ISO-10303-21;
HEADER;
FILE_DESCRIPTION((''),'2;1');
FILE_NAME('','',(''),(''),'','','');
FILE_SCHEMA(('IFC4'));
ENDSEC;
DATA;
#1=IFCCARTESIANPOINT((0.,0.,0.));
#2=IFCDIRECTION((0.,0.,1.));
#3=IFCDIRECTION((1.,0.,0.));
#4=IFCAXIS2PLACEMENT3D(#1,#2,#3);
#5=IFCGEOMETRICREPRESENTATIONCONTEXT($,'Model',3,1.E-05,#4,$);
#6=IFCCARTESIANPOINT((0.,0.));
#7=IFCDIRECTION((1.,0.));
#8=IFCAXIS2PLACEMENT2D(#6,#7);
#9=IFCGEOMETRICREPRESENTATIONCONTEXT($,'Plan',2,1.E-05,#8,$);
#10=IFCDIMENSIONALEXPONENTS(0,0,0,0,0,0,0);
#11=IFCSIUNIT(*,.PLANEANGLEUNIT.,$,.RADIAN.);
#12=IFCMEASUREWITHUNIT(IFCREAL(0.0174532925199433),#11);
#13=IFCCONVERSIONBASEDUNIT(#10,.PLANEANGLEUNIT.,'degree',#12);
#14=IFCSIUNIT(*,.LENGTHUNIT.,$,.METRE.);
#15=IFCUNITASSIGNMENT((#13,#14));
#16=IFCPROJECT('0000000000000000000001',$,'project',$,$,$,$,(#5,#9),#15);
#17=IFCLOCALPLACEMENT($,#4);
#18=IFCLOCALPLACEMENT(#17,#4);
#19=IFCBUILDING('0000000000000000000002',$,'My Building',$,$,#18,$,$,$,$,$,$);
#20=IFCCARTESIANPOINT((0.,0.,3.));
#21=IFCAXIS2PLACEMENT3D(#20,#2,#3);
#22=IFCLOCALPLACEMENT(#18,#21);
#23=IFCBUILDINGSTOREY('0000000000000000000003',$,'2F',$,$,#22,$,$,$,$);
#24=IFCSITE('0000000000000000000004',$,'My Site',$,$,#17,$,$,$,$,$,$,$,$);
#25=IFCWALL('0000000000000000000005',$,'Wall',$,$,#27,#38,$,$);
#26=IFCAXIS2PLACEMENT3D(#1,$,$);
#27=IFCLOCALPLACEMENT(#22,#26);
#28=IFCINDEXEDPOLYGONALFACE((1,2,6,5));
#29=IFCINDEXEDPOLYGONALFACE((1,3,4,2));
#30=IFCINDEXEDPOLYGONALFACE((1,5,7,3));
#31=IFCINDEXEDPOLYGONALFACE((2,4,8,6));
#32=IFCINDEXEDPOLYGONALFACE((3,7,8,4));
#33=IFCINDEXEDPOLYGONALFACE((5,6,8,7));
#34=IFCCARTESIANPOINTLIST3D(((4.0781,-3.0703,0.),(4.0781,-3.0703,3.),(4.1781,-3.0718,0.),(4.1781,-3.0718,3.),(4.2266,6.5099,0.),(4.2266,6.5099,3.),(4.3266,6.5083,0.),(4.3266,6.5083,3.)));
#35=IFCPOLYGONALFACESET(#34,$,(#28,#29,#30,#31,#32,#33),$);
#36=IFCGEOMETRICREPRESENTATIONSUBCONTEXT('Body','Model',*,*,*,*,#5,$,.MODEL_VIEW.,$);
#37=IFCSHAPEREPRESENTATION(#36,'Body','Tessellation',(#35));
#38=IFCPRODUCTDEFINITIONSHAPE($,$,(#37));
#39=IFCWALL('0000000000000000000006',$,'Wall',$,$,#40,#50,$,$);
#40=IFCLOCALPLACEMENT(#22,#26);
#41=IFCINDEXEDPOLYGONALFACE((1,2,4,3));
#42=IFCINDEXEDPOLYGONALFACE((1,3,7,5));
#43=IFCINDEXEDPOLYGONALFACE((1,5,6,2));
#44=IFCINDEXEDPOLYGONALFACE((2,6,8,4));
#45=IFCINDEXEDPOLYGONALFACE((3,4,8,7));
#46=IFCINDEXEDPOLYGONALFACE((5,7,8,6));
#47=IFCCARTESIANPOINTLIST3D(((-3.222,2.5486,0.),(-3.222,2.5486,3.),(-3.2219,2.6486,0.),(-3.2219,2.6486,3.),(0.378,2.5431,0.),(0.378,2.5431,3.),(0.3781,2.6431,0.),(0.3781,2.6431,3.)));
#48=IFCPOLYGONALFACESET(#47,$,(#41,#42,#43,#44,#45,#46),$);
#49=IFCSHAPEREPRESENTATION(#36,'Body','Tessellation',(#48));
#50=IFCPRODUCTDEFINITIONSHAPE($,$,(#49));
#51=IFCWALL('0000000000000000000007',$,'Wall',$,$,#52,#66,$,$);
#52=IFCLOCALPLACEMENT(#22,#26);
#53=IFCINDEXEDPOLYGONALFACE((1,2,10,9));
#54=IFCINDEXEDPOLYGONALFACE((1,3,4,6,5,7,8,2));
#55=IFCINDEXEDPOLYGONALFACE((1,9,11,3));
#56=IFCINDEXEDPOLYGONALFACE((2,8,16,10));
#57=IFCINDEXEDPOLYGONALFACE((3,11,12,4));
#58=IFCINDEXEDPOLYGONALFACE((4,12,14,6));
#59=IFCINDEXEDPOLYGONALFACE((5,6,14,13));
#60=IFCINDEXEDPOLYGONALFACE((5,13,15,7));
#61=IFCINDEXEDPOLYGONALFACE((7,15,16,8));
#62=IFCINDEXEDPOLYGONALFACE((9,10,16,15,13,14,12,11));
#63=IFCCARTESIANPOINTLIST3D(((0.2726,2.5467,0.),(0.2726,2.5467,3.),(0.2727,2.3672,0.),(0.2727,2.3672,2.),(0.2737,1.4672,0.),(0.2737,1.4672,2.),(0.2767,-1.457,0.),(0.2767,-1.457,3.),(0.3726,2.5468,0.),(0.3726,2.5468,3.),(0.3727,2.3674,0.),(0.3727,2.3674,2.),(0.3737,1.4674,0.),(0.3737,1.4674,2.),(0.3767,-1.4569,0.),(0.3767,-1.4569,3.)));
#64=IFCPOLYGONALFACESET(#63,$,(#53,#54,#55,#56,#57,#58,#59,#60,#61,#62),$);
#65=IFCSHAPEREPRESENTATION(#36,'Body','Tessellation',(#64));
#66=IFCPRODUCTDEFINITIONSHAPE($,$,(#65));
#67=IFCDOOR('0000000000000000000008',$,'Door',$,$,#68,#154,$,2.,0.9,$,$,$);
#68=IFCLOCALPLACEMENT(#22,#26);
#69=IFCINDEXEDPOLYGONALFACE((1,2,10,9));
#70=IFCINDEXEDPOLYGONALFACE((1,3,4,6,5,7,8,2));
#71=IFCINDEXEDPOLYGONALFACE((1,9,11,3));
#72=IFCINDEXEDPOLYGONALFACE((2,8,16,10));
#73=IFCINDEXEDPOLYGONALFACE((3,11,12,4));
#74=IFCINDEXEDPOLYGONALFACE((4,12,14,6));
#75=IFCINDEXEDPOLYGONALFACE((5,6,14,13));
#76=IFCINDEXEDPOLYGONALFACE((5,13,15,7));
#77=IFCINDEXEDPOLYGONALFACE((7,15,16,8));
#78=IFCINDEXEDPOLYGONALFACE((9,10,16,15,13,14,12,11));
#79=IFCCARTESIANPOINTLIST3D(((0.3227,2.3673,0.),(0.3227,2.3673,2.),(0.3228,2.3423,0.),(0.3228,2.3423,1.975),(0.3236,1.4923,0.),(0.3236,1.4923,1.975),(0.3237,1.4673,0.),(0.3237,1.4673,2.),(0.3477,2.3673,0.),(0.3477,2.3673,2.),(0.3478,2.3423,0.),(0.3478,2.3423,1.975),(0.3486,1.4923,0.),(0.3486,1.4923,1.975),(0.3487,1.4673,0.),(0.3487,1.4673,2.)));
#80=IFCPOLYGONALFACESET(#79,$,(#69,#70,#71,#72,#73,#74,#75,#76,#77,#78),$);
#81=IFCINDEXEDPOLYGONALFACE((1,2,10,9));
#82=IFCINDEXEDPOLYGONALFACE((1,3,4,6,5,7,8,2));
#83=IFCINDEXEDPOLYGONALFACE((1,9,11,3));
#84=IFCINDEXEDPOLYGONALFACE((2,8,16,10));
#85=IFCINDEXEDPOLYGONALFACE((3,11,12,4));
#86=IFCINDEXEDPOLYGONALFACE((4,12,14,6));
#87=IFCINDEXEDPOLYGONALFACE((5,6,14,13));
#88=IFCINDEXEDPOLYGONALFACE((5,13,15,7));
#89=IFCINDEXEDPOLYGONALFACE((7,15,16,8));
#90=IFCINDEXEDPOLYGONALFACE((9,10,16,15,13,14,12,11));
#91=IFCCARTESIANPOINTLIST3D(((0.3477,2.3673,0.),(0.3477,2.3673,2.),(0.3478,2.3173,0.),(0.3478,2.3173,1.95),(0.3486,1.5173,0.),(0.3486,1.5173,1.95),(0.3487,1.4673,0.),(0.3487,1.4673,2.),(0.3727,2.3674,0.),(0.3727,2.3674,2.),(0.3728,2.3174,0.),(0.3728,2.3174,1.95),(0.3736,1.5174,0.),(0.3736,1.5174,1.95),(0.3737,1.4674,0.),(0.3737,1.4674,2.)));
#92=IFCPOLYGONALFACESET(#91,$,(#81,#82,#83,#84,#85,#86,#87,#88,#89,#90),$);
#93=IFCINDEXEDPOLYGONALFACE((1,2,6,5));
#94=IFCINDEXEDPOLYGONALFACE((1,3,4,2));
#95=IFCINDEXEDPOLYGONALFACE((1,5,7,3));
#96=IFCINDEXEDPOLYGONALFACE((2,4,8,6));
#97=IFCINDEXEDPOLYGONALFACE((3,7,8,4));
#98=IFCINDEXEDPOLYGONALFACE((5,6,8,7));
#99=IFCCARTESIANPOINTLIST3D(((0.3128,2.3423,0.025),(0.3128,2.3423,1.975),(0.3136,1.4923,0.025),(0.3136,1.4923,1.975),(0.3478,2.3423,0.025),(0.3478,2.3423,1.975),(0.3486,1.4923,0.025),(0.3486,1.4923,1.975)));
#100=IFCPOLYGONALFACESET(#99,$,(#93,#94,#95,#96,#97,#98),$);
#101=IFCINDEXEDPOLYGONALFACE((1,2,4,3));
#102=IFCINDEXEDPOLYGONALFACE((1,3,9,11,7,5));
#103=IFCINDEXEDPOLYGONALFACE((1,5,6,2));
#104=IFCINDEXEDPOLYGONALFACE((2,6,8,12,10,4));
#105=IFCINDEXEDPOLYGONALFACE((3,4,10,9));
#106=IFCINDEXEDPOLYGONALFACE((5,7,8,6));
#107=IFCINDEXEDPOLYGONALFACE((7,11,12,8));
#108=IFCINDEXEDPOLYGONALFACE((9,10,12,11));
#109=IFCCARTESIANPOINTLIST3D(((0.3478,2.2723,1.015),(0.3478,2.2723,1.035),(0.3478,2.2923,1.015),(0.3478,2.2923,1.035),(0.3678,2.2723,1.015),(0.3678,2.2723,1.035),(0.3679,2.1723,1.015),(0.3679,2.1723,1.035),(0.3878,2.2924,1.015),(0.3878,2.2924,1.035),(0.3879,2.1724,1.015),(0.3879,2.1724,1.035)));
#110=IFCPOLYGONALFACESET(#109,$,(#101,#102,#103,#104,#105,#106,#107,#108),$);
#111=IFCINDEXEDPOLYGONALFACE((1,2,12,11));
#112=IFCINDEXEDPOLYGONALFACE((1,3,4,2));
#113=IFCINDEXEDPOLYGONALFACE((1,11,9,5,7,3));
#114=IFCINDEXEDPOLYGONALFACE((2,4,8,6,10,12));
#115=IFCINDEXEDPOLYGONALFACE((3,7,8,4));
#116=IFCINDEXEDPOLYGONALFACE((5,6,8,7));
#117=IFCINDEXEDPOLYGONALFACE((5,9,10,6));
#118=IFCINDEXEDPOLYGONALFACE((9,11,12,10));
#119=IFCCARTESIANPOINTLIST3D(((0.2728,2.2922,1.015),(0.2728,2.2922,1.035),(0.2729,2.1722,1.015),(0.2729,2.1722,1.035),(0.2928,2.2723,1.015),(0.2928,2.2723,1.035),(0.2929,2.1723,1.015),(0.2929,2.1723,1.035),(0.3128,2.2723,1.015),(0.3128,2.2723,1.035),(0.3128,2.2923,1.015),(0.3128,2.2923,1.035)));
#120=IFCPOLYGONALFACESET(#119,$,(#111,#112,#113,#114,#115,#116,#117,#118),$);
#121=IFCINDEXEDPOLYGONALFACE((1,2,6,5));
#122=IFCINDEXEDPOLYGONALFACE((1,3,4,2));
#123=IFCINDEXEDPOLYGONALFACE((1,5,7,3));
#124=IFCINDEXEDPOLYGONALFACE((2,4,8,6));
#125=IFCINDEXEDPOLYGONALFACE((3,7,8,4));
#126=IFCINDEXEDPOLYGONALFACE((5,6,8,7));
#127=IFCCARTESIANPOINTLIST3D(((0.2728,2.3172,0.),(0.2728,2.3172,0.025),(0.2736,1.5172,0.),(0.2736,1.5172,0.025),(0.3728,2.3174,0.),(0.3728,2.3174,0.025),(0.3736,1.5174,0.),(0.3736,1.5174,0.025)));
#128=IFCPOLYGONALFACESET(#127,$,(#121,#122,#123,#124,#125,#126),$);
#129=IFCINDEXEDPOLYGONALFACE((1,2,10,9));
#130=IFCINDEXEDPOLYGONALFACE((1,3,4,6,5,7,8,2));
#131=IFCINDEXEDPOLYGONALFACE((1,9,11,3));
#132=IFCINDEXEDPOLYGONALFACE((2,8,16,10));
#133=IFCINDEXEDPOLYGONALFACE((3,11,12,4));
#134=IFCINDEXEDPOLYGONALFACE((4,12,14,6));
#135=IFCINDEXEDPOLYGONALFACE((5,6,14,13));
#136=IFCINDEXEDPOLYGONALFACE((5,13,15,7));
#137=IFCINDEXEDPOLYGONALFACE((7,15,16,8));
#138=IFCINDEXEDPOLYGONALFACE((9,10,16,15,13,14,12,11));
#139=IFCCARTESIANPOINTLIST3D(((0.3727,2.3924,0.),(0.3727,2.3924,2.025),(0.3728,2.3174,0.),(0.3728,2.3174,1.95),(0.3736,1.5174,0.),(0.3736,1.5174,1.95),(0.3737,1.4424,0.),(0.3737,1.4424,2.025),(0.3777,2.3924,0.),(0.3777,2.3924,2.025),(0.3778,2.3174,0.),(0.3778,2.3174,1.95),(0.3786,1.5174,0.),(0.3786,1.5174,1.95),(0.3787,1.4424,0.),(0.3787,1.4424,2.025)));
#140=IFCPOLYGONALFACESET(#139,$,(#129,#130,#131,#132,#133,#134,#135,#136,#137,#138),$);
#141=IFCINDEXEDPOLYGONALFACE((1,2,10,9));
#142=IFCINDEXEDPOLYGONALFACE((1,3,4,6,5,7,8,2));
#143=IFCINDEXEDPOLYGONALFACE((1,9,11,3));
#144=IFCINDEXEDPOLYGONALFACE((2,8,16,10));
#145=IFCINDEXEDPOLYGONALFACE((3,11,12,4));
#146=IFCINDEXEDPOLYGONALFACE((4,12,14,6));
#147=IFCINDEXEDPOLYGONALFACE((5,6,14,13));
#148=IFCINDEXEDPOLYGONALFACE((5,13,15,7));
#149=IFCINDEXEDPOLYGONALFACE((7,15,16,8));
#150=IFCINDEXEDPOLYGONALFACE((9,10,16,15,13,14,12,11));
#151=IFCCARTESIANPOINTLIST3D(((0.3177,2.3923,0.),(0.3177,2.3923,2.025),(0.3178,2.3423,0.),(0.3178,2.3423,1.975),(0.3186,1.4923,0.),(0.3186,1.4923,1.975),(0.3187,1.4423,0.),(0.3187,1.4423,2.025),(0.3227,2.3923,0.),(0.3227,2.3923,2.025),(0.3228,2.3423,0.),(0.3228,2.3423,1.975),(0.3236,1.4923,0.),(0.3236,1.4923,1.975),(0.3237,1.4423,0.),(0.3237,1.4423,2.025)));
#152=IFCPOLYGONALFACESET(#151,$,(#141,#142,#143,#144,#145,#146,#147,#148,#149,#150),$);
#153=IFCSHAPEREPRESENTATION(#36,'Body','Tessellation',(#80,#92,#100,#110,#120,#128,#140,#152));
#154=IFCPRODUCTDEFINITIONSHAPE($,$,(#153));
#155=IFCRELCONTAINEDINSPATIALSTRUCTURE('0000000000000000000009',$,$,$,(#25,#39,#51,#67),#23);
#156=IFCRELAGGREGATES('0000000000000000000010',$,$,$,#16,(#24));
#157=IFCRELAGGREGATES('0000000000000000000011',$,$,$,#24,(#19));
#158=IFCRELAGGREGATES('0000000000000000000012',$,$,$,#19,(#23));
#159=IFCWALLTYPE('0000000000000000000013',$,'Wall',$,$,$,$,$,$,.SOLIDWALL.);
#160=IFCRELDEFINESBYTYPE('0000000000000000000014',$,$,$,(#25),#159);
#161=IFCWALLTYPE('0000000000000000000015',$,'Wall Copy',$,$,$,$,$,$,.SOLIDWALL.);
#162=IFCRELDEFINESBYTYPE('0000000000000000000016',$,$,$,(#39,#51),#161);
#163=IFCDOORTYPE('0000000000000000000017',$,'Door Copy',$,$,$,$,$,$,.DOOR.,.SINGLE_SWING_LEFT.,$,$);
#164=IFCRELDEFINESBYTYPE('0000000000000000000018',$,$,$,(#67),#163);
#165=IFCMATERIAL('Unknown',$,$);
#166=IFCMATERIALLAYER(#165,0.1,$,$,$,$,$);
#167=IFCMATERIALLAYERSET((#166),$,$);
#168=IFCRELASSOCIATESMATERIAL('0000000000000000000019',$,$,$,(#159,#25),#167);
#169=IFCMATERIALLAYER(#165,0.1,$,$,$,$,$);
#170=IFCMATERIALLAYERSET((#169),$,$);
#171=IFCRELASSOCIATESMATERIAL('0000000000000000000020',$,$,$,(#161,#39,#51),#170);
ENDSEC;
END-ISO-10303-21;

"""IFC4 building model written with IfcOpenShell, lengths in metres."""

from ifc_helpers import new_model, entity, si_unit, converted_unit, frame, origin_with_axes, origin_2d_with_axis, place, context, subcontext, project, spatial, line, indexed_curve, outline, extrude, shape, source, transform, mapped, material, layer, layer_set, layer_usage, type_object, type_shapes, element, fill, save


model = new_model("IFC4")

# Units and contexts
model_context = context("Model", 3, precision=1e-05, world=origin_with_axes())
plan_context = context("Plan", 2, precision=1e-05, world=origin_2d_with_axis())
body_context_1 = subcontext(model_context, "Body", "Model", "MODEL_VIEW")
body_context_2 = subcontext(plan_context, "Body", "Plan", "PLAN_VIEW")
ifc_project = project(units=[converted_unit("PLANEANGLEUNIT", "degree", entity("IfcReal", 0.0174532925199433), si_unit("PLANEANGLEUNIT", "RADIAN"), dimensions=[0, 0, 0, 0, 0, 0, 0]), si_unit("LENGTHUNIT", "METRE")], contexts=[model_context, plan_context])

# Site, building, storey
site_placement = place(None, origin_with_axes())
site = spatial("IfcSite", under=ifc_project, at=site_placement, Name="My Site")
building_placement = place(site_placement, origin_with_axes())
building = spatial("IfcBuilding", under=site, at=building_placement, Name="My Building")
storey_placement = place(building_placement, frame((0.0, 0.0, 3.0), z_axis=(0.0, 0.0, 1.0), x_axis=(1.0, 0.0, 0.0)))
storey = spatial("IfcBuildingStorey", under=building, at=storey_placement, Name="2F")

# Walls
ifc_material = material(Name="Unknown")
ifc_layer_1 = layer(ifc_material, 0.1)
ifc_layer_set_1 = layer_set([ifc_layer_1])
ifc_layer_usage_1 = layer_usage(ifc_layer_set_1, "AXIS2", "POSITIVE", 0.0)
wall_type_1 = type_object("IfcWallType", Name="Wall", PredefinedType="SOLIDWALL", material=ifc_layer_set_1)
wall_1_placement = place(storey_placement, frame((4.2266, 6.5099, 0.0), z_axis=(0.0, 0.0, 1.0), x_axis=(-0.015497, -0.99988, 0.0)))
element("IfcWall", 1, at=wall_1_placement, inside=storey, type_object=wall_type_1, material=ifc_layer_usage_1, Name="Wall", context=body_context_1, shape_type="SweptSolid", body=[
    extrude(outline(indexed_curve([(0.0, 0.0), (0.0, 0.1), (9.5813, 0.1), (9.5813, 0.0)], segments=[line(1, 2, 3, 4, 1)])), origin_with_axes(), (0.0, 0.0, 1.0), 3.0),
])
ifc_layer_2 = layer(ifc_material, 0.1)
ifc_layer_set_2 = layer_set([ifc_layer_2])
ifc_layer_usage_2 = layer_usage(ifc_layer_set_2, "AXIS2", "POSITIVE", 0.0)
wall_type_2 = type_object("IfcWallType", Name="Wall Copy", PredefinedType="SOLIDWALL", material=ifc_layer_set_2)
wall_2_placement = place(storey_placement, frame((0.3781, 2.6431, 0.0), z_axis=(0.0, 0.0, 1.0), x_axis=(-0.999999, 0.001521, 0.0)))
element("IfcWall", 2, at=wall_2_placement, inside=storey, type_object=wall_type_2, material=ifc_layer_usage_2, Name="Wall", context=body_context_1, shape_type="SweptSolid", body=[
    extrude(outline(indexed_curve([(0.0, 0.0), (0.0, 0.1), (3.6, 0.1), (3.6, 0.0)], segments=[line(1, 2, 3, 4, 1)])), origin_with_axes(), (0.0, 0.0, 1.0), 3.0),
])

# Wall, opening, door
ifc_layer_usage_3 = layer_usage(ifc_layer_set_2, "AXIS2", "POSITIVE", 0.0)
wall_3_placement = place(storey_placement, frame((0.3767, -1.4569, 0.0), z_axis=(0.0, 0.0, 1.0), x_axis=(-0.001028, 0.999999, 0.0)))
wall_3 = element("IfcWall", 3, at=wall_3_placement, inside=storey, type_object=wall_type_2, material=ifc_layer_usage_3, Name="Wall", context=body_context_1, shape_type="SweptSolid", body=[
    extrude(outline(indexed_curve([(0.0, 0.0), (0.0, 0.1), (4.0037, 0.1), (4.0037, 0.0)], segments=[line(1, 2, 3, 4, 1)])), origin_with_axes(), (0.0, 0.0, 1.0), 3.0),
])
shared_shape_1 = source(origin_with_axes(), body_context_1, "Body", "SweptSolid", [
    extrude(outline(indexed_curve([(0.0, 0.0), (0.9, 0.0), (0.9, 2.0), (0.0, 2.0)], segments=[line(1, 2, 3, 4, 1)])), frame((0.0, -0.6, 0.0), z_axis=(0.0, -1.0, 0.0), x_axis=(1.0, 0.0, 0.0)), (0.0, 0.0, -1.0), 1.2),
])
opening_1_placement = place(wall_3_placement, frame((2.9242, 0.0, 0.0), z_axis=(0.0, 0.0, 1.0), x_axis=(1.0, 0.0, 0.0)))
opening_1 = element("IfcOpeningElement", 4, at=opening_1_placement, cuts=wall_3, PredefinedType="OPENING", context=body_context_1, shape_type="MappedRepresentation", body=[
    mapped(shared_shape_1, transform((0.0, 0.0, 0.0), x_axis=(1.0, 0.0, 0.0), y_axis=(0.0, 1.0, 0.0), z_axis=(0.0, 0.0, 1.0), scale=1.0)),
])
door_type = type_object("IfcDoorType", Name="Door Copy", OperationType="SINGLE_SWING_LEFT", PredefinedType="DOOR")
shared_shape_2 = source(origin_with_axes(), body_context_1, "Body", "SweptSolid", [
    extrude(outline(indexed_curve([(0.0, 0.0), (0.0, 2.0), (0.9, 2.0), (0.9, 0.0), (0.875, 0.0), (0.875, 1.975), (0.025, 1.975), (0.025, 0.0)], segments=[line(1, 2, 3, 4, 5, 6, 7, 8, 1)])), frame((0.0, 0.025, 0.0), z_axis=(0.0, -1.0, 0.0), x_axis=(1.0, 0.0, 0.0)), (0.0, 0.0, -1.0), 0.025),
    extrude(outline(indexed_curve([(0.0, 0.0), (0.0, 2.0), (0.9, 2.0), (0.9, 0.0), (0.85, 0.0), (0.85, 1.95), (0.05, 1.95), (0.05, 0.0)], segments=[line(1, 2, 3, 4, 5, 6, 7, 8, 1)])), frame((0.0, 0.0, 0.0), z_axis=(0.0, -1.0, 0.0), x_axis=(1.0, 0.0, 0.0)), (0.0, 0.0, -1.0), 0.025),
    extrude(outline(indexed_curve([(0.0, 0.0), (0.85, 0.0), (0.85, 0.035), (0.0, 0.035)], segments=[line(1, 2, 3, 4, 1)])), frame((0.025, 0.025, 0.025), z_axis=(0.0, 0.0, 1.0), x_axis=(1.0, 0.0, 0.0)), (0.0, 0.0, 1.0), 1.95),
    extrude(outline(indexed_curve([(0.0, 0.0), (0.0, -0.04), (-0.12, -0.04), (-0.12, -0.02), (-0.02, -0.02), (-0.02, 0.0)], segments=[line(1, 2, 3, 4, 5, 6, 1)])), frame((0.825, 0.025, 1.015), z_axis=(0.0, 0.0, 1.0), x_axis=(1.0, 0.0, 0.0)), (0.0, 0.0, 1.0), 0.02),
    extrude(outline(indexed_curve([(0.0, 0.0), (0.0, 0.04), (-0.12, 0.04), (-0.12, 0.02), (-0.02, 0.02), (-0.02, 0.0)], segments=[line(1, 2, 3, 4, 5, 6, 1)])), frame((0.825, 0.06, 1.015), z_axis=(0.0, 0.0, 1.0), x_axis=(1.0, 0.0, 0.0)), (0.0, 0.0, 1.0), 0.02),
    extrude(outline(indexed_curve([(0.0, 0.0), (0.8, 0.0), (0.8, 0.1), (0.0, 0.1)], segments=[line(1, 2, 3, 4, 1)])), frame((0.05, 0.0, 0.0), z_axis=(0.0, 0.0, 1.0), x_axis=(1.0, 0.0, 0.0)), (0.0, 0.0, 1.0), 0.025),
    extrude(outline(indexed_curve([(0.0, 0.0), (0.0, 2.025), (0.95, 2.025), (0.95, 0.0), (0.875, 0.0), (0.875, 1.95), (0.075, 1.95), (0.075, 0.0)], segments=[line(1, 2, 3, 4, 5, 6, 7, 8, 1)])), frame((-0.025, -0.005, 0.0), z_axis=(0.0, -1.0, 0.0), x_axis=(1.0, 0.0, 0.0)), (0.0, 0.0, -1.0), 0.005),
    extrude(outline(indexed_curve([(0.0, 0.0), (0.0, 2.025), (0.95, 2.025), (0.95, 0.0), (0.9, 0.0), (0.9, 1.975), (0.05, 1.975), (0.05, 0.0)], segments=[line(1, 2, 3, 4, 5, 6, 7, 8, 1)])), frame((-0.025, 0.05, 0.0), z_axis=(0.0, -1.0, 0.0), x_axis=(1.0, 0.0, 0.0)), (0.0, 0.0, -1.0), 0.005),
])
shared_shape_3 = source(origin_with_axes(), body_context_2, "Body", "Curve2D", [
    entity("IfcIndexedPolyCurve", entity("IfcCartesianPointList2D", [[0.0, 0.0], [0.0, 0.05], [0.025, 0.05], [0.025, 0.025], [0.05, 0.025], [0.05, 0.0]]), [entity("IfcLineIndex", [1, 2, 3, 4, 5, 6, 1])]),
    entity("IfcIndexedPolyCurve", entity("IfcCartesianPointList2D", [[0.9, 0.0], [0.9, 0.05], [0.875, 0.05], [0.875, 0.025], [0.85, 0.025], [0.85, 0.0]]), [entity("IfcLineIndex", [1, 2, 3, 4, 5, 6, 1])]),
    entity("IfcTrimmedCurve", entity("IfcEllipse", entity("IfcAxis2Placement2D", entity("IfcCartesianPoint", [0.06, 0.05]), entity("IfcDirection", [1.0, 0.0])), 0.815, 0.85), [entity("IfcCartesianPoint", [0.875, 0.05])], [entity("IfcCartesianPoint", [0.06, 0.9])], True, "CARTESIAN"),
    entity("IfcIndexedPolyCurve", entity("IfcCartesianPointList2D", [[0.025, 0.05], [0.06, 0.05], [0.06, 0.9], [0.025, 0.9]]), [entity("IfcLineIndex", [1, 2, 3, 4, 1])]),
])
type_shapes(door_type, [shared_shape_2, shared_shape_3])
door_1_placement = place(opening_1_placement, frame((0.0, 0.0, 0.0), z_axis=(0.0, 0.0, 1.0), x_axis=(1.0, 0.0, 0.0)))
door_1 = element("IfcDoor", 5, at=door_1_placement, inside=storey, type_object=door_type, Name="Door", OverallHeight=2.0, OverallWidth=0.9, shapes=[
    shape(body_context_1, "Body", "MappedRepresentation", [mapped(shared_shape_2, transform((0.0, 0.0, 0.0), x_axis=(1.0, 0.0, 0.0), y_axis=(0.0, 1.0, 0.0), z_axis=(0.0, 0.0, 1.0), scale=1.0))]),
    shape(body_context_2, "Body", "MappedRepresentation", [mapped(shared_shape_3, transform((0.0, 0.0, 0.0), x_axis=(1.0, 0.0, 0.0), y_axis=(0.0, 1.0, 0.0), z_axis=(0.0, 0.0, 1.0), scale=1.0))]),
])
fill(opening_1, door_1)

save(model, "model.ifc")
